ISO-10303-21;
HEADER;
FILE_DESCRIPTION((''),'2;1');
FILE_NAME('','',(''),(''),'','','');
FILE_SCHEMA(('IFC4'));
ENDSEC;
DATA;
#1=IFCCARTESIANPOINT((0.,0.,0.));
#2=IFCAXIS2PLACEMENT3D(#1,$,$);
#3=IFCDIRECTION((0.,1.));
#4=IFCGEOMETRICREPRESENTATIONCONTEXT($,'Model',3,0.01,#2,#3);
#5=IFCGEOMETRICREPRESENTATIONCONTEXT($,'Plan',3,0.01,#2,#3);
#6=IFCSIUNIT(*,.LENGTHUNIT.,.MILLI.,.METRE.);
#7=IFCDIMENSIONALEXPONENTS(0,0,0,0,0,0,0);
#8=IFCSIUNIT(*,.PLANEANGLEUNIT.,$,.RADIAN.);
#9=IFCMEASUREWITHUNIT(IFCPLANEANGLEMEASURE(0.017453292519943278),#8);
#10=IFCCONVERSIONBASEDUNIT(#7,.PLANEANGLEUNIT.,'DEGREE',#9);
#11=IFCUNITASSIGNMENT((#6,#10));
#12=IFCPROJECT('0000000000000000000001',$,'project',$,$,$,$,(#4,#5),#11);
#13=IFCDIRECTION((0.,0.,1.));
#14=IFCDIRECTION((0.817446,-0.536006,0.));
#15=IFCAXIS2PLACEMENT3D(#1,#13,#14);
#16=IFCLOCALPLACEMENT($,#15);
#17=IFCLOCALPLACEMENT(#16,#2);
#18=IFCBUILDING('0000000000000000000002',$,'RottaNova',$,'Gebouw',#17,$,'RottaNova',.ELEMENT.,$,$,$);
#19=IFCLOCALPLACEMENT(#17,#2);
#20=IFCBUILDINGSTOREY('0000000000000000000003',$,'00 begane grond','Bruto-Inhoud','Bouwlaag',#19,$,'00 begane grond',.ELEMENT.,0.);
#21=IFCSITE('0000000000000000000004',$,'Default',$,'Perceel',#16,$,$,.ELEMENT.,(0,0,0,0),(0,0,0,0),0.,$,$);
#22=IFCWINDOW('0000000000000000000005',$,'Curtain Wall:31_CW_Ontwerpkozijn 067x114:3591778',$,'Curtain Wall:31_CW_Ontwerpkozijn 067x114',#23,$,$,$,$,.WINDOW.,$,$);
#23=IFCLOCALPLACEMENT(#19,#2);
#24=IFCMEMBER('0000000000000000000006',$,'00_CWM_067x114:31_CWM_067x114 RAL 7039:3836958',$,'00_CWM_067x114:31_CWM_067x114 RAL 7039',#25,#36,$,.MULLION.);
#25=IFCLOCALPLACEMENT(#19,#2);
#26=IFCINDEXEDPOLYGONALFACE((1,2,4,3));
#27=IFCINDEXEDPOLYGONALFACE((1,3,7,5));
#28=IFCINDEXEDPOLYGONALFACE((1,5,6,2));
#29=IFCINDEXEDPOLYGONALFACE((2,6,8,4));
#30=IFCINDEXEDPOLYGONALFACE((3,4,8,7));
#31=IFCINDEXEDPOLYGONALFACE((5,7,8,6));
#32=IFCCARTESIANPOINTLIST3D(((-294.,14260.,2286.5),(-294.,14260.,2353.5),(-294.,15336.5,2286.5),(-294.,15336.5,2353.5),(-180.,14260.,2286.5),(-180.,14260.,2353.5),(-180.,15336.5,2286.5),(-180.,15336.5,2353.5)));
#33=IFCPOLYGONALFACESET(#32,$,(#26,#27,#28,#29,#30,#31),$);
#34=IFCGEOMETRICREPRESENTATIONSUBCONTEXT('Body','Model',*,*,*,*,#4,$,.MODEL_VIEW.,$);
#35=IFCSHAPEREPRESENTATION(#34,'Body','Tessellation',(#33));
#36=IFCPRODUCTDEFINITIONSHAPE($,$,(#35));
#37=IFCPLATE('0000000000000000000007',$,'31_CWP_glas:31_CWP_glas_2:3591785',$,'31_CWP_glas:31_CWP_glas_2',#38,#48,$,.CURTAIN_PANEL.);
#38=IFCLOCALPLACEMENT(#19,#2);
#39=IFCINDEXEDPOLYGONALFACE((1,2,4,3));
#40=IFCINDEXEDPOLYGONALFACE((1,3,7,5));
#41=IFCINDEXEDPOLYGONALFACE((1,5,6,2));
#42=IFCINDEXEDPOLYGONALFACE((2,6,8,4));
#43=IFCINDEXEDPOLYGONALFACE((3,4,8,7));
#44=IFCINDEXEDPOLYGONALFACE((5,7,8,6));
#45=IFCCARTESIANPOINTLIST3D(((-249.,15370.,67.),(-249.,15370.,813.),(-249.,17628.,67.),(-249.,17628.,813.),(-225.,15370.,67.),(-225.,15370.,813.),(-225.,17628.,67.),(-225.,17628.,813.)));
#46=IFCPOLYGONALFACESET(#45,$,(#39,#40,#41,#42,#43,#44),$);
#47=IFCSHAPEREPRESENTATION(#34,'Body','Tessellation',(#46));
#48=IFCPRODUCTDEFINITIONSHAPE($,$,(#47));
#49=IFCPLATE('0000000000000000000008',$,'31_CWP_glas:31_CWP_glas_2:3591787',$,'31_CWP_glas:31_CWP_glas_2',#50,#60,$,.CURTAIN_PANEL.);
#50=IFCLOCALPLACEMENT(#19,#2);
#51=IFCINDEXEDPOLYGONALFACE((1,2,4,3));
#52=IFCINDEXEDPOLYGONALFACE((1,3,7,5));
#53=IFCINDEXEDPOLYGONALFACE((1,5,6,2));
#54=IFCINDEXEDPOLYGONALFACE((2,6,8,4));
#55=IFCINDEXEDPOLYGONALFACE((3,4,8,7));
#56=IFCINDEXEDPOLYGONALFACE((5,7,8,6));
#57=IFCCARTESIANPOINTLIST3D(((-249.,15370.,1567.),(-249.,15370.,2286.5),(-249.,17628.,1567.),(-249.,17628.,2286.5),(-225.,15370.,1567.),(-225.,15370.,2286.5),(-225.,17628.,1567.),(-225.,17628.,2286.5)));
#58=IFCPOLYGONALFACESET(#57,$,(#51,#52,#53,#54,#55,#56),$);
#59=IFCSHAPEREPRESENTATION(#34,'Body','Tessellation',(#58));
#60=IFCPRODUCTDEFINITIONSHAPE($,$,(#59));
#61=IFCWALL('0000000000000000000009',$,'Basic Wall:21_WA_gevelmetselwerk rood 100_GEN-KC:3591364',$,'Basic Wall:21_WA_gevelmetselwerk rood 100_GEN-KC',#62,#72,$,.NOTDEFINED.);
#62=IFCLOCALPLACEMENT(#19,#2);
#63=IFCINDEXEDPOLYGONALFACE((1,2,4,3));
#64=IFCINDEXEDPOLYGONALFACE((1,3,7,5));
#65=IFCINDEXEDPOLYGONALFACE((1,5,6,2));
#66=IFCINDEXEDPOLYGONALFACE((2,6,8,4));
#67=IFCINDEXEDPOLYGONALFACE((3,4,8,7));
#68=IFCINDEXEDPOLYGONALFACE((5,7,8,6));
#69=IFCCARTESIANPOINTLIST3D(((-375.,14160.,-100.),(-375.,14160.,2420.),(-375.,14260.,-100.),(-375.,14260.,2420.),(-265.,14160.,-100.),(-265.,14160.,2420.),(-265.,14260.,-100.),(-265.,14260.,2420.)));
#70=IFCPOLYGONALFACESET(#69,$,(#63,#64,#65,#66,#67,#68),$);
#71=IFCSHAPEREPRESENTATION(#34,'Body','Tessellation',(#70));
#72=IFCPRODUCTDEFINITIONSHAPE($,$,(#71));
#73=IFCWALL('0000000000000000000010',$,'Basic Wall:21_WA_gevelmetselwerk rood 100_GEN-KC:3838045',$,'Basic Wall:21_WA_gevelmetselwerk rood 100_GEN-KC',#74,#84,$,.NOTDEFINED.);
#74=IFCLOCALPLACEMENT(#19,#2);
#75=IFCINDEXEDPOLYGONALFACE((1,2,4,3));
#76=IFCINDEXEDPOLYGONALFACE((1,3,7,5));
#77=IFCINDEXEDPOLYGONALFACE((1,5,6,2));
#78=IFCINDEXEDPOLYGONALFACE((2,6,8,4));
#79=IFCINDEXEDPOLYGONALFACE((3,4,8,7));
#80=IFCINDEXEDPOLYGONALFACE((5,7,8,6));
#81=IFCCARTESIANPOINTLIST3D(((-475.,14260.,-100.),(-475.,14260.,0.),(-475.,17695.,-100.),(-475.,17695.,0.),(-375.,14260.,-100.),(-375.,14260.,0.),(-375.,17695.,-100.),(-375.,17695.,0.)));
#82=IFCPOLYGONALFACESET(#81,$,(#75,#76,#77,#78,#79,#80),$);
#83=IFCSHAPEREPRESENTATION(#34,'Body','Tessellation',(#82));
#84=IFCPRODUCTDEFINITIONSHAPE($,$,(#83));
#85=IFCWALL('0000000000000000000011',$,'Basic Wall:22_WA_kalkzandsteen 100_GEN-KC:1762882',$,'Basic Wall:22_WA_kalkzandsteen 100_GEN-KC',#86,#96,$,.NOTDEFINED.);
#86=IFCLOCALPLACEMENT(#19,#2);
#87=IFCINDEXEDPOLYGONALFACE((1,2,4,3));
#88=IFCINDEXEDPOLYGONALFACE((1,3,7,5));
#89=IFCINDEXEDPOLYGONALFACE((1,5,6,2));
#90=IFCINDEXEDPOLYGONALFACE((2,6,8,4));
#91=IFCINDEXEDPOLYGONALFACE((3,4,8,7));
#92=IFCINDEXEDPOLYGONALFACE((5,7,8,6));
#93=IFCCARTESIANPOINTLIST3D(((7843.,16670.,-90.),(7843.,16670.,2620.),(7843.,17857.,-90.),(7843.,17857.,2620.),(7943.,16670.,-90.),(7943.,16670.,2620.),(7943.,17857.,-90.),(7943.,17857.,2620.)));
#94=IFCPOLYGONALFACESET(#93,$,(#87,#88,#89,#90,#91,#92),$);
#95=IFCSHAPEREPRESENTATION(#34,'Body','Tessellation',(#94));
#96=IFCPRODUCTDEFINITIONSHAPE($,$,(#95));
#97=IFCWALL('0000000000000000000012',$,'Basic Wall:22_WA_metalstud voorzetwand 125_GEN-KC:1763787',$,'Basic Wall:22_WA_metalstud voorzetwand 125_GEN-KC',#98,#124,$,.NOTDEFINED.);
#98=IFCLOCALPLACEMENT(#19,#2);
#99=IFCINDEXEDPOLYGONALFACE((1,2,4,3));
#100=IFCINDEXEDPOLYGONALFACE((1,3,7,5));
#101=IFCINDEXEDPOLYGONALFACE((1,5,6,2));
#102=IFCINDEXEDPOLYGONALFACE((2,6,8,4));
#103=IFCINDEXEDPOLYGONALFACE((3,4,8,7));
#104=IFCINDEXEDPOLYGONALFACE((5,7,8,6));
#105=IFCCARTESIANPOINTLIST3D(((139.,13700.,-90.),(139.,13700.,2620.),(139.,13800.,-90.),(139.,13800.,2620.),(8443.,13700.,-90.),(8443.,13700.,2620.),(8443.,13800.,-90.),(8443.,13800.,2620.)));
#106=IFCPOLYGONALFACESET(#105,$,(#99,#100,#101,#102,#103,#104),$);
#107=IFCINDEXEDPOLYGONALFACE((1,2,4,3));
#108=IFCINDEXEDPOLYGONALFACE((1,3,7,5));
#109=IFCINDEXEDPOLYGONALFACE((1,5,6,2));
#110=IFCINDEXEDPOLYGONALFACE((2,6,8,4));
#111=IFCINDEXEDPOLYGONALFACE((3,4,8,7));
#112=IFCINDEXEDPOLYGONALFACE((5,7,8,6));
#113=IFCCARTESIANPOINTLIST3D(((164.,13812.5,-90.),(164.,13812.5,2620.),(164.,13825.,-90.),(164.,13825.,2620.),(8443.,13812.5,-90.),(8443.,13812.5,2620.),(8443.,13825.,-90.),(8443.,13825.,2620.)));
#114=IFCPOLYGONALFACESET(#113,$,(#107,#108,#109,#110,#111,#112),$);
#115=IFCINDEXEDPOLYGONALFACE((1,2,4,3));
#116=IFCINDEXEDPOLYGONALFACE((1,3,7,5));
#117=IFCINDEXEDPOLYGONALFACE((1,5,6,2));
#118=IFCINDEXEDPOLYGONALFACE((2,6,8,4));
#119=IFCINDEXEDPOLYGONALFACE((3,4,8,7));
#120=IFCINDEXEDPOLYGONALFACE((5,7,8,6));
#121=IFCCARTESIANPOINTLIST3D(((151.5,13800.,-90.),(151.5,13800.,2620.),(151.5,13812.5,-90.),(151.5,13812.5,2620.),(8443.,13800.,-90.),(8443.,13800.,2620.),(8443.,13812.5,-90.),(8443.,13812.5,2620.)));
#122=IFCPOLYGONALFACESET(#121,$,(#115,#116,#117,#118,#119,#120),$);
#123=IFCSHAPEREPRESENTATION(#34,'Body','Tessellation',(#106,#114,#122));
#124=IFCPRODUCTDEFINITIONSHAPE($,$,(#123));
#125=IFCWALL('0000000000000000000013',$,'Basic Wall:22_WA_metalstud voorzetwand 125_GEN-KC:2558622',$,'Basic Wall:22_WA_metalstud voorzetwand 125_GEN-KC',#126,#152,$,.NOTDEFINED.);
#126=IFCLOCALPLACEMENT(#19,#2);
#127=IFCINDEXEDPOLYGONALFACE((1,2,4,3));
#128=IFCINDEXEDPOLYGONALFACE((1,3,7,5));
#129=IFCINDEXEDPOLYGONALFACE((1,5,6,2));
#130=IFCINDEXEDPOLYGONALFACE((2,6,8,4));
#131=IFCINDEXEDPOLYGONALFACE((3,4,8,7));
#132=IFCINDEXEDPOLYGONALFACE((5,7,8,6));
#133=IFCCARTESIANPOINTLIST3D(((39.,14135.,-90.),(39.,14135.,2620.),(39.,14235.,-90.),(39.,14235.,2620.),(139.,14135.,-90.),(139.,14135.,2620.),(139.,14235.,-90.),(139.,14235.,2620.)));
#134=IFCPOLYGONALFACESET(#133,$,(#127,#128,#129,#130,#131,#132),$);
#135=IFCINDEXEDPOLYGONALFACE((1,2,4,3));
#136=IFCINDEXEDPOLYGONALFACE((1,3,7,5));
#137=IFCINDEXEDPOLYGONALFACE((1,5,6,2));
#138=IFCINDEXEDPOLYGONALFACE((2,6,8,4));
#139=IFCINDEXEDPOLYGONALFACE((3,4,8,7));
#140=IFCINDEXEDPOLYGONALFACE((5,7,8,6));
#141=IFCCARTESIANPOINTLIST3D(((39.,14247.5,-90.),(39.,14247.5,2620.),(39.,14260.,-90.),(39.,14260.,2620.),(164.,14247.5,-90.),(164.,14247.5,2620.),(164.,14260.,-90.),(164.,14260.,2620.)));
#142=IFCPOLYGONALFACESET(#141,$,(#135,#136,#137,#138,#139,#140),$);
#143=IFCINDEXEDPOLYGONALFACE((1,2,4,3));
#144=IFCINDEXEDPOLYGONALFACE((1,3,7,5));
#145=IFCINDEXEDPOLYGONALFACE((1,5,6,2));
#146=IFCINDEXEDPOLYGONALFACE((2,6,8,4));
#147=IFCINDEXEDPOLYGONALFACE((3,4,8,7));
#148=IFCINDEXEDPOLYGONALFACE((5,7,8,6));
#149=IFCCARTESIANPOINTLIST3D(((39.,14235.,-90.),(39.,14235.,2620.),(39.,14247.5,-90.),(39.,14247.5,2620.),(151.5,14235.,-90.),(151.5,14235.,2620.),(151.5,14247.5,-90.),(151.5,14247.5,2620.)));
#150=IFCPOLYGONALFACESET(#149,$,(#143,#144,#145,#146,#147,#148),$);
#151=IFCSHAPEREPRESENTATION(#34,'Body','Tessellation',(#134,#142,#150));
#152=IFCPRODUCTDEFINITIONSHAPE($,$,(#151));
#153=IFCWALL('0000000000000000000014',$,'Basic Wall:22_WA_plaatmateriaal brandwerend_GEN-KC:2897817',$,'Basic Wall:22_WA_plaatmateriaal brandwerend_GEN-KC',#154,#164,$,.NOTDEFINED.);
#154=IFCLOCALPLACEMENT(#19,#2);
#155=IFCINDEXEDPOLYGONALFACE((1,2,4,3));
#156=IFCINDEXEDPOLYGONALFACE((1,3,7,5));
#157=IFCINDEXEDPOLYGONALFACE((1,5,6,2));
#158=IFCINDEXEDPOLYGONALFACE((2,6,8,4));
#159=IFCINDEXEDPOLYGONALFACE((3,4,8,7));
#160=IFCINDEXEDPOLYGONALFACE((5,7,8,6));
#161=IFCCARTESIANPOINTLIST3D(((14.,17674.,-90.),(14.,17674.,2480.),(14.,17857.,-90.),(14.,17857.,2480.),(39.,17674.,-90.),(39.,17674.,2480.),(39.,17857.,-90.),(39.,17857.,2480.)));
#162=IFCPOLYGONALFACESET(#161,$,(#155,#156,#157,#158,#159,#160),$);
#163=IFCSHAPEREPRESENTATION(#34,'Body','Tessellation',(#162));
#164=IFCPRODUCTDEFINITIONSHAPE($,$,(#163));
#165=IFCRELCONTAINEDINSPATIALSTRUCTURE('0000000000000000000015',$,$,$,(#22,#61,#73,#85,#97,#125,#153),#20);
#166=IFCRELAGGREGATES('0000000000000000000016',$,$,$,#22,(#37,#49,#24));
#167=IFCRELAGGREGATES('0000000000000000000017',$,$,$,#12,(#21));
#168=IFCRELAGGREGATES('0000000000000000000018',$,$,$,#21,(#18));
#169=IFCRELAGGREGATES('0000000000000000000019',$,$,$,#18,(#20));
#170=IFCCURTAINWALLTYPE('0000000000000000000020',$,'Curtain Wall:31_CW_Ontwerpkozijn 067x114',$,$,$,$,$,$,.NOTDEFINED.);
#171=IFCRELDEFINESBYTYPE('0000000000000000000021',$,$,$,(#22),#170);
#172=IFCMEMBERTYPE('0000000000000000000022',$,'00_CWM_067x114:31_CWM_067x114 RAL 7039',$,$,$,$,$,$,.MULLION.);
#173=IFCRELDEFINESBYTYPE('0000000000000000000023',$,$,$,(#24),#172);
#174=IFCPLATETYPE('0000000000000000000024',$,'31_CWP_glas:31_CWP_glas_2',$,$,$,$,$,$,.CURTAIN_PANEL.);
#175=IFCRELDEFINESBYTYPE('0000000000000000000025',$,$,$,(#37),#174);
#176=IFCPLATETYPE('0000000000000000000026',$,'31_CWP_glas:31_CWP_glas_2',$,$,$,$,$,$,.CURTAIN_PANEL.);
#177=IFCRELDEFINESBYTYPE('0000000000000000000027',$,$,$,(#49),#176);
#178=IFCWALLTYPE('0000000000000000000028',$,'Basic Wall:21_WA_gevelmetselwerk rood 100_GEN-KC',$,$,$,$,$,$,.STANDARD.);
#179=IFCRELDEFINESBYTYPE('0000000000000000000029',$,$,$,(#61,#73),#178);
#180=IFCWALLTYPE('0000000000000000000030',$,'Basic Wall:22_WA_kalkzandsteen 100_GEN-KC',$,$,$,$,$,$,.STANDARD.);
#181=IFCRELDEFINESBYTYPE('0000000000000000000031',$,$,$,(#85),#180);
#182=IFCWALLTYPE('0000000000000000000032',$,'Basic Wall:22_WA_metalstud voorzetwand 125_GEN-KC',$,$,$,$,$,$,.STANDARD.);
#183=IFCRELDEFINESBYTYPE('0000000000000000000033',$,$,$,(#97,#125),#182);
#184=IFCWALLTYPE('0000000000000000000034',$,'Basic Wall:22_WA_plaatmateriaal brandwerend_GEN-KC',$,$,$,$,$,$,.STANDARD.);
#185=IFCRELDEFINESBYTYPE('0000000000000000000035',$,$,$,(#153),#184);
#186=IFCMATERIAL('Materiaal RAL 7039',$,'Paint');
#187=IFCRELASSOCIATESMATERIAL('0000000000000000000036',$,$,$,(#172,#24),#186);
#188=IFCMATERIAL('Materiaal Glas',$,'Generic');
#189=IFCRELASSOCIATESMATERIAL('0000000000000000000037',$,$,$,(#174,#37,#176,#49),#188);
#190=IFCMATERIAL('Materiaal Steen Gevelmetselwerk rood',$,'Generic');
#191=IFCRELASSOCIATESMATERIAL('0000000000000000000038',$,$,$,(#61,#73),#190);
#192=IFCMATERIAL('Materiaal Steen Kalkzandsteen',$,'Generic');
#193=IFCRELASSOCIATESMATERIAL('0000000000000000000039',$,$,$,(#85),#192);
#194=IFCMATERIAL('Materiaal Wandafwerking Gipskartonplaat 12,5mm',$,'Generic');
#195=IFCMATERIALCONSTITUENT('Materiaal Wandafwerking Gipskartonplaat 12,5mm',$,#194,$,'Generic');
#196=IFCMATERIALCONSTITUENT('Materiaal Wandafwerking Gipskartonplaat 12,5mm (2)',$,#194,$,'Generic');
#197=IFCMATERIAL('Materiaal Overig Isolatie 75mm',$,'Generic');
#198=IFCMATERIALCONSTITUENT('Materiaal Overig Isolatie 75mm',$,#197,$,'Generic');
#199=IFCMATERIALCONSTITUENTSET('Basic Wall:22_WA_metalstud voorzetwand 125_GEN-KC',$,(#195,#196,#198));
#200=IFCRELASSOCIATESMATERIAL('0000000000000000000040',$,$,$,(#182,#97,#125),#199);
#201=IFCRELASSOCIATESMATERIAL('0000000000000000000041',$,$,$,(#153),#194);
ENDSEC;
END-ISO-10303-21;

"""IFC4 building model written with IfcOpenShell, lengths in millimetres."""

from ifc_helpers import new_model, entity, si_unit, converted_unit, direction, frame, origin, place, context, subcontext, project, spatial, indexed_curve, outline, extrude, source, transform, mapped, material, constituent, constituent_set, type_object, type_shapes, element, aggregate, save


model = new_model("IFC4")

# Units and contexts
model_context = context("Model", 3, precision=0.01, world=origin(), true_north=direction((0.0, 1.0)))
plan_context = context("Plan", 3, precision=0.01, world=origin(), true_north=direction((0.0, 1.0)))
body_context = subcontext(model_context, "Body", "Model", "MODEL_VIEW")
ifc_project = project(units=[si_unit("LENGTHUNIT", "METRE", prefix="MILLI"), converted_unit("PLANEANGLEUNIT", "DEGREE", entity("IfcPlaneAngleMeasure", 0.017453292519943278), si_unit("PLANEANGLEUNIT", "RADIAN"), dimensions=[0, 0, 0, 0, 0, 0, 0])], contexts=[model_context, plan_context])

# Site, building, storey
site_placement = place(None, frame((0.0, 0.0, 0.0), z_axis=(0.0, 0.0, 1.0), x_axis=(0.817446, -0.536006, 0.0)))
site = spatial("IfcSite", under=ifc_project, at=site_placement, Name="Default", ObjectType="Perceel", CompositionType="ELEMENT", RefLatitude=(0, 0, 0, 0), RefLongitude=(0, 0, 0, 0), RefElevation=0.0)
building_placement = place(site_placement, origin())
building = spatial("IfcBuilding", under=site, at=building_placement, Name="RottaNova", ObjectType="Gebouw", LongName="RottaNova", CompositionType="ELEMENT")
storey_placement = place(building_placement, origin())
storey = spatial("IfcBuildingStorey", under=building, at=storey_placement, Name="00 begane grond", Description="Bruto-Inhoud", ObjectType="Bouwlaag", LongName="00 begane grond", CompositionType="ELEMENT", Elevation=0.0)

# Window, member, plates
curtain_wall_type = type_object("IfcCurtainWallType", Name="Curtain Wall:31_CW_Ontwerpkozijn 067x114", PredefinedType="NOTDEFINED")
window_1_placement = place(storey_placement, origin())
window_1 = element("IfcWindow", 1, at=window_1_placement, inside=storey, type_object=curtain_wall_type, Name="Curtain Wall:31_CW_Ontwerpkozijn 067x114:3591778", ObjectType="Curtain Wall:31_CW_Ontwerpkozijn 067x114", PredefinedType="WINDOW")
ifc_material_1 = material(Name="Materiaal RAL 7039", Category="Paint")
member_type_1 = type_object("IfcMemberType", Name="00_CWM_067x114:31_CWM_067x114 RAL 7039", PredefinedType="MULLION", material=ifc_material_1)
shared_shape_1 = source(origin(), body_context, "Body", "SweptSolid", [
    extrude(outline(indexed_curve([(-33.5, -57.0), (33.5, -57.0), (33.5, 57.0), (-33.5, 57.0), (-33.5, -57.0)], self_intersect=False)), frame((0.0, -57.0, -1076.5), z_axis=(0.0, 0.0, 1.0), x_axis=(-1.0, 0.0, 0.0)), (0.0, 0.0, 1.0), 1076.5),
])
type_shapes(member_type_1, [shared_shape_1])
member_1_placement = place(window_1_placement, frame((-180.0, 15336.5, 2320.0), z_axis=(0.0, 1.0, 0.0), x_axis=(0.0, 0.0, 1.0)))
member_1 = element("IfcMember", 2, at=member_1_placement, type_object=member_type_1, material=ifc_material_1, Name="00_CWM_067x114:31_CWM_067x114 RAL 7039:3836958", ObjectType="00_CWM_067x114:31_CWM_067x114 RAL 7039", PredefinedType="MULLION", context=body_context, shape_type="MappedRepresentation", body=[
    mapped(shared_shape_1, transform((0.0, 0.0, 0.0), scale=1.0)),
])
ifc_material_2 = material(Name="Materiaal Glas", Category="Generic")
plate_type_1 = type_object("IfcPlateType", Name="31_CWP_glas:31_CWP_glas_2", PredefinedType="CURTAIN_PANEL", material=ifc_material_2)
shared_shape_2 = source(origin(), body_context, "Body", "SweptSolid", [
    extrude(outline(indexed_curve([(-12.0, -1129.0), (12.0, -1129.0), (12.0, 1129.0), (-12.0, 1129.0), (-12.0, -1129.0)], self_intersect=False)), frame((0.0, 57.0, 0.0), z_axis=(0.0, 0.0, 1.0), x_axis=(0.0, 1.0, 0.0)), (0.0, 0.0, 1.0), 746.0),
])
type_shapes(plate_type_1, [shared_shape_2])
plate_1_placement = place(window_1_placement, frame((-180.0, 16499.0, 67.0), z_axis=(0.0, 0.0, 1.0), x_axis=(0.0, 1.0, 0.0)))
plate_1 = element("IfcPlate", 3, at=plate_1_placement, type_object=plate_type_1, material=ifc_material_2, Name="31_CWP_glas:31_CWP_glas_2:3591785", ObjectType="31_CWP_glas:31_CWP_glas_2", PredefinedType="CURTAIN_PANEL", context=body_context, shape_type="MappedRepresentation", body=[
    mapped(shared_shape_2, transform((0.0, 0.0, 0.0), scale=1.0)),
])
plate_type_2 = type_object("IfcPlateType", Name="31_CWP_glas:31_CWP_glas_2", PredefinedType="CURTAIN_PANEL", material=ifc_material_2)
shared_shape_3 = source(origin(), body_context, "Body", "SweptSolid", [
    extrude(outline(indexed_curve([(-12.0, -1129.0), (12.0, -1129.0), (12.0, 1129.0), (-12.0, 1129.0), (-12.0, -1129.0)], self_intersect=False)), frame((0.0, 57.0, 0.0), z_axis=(0.0, 0.0, 1.0), x_axis=(0.0, 1.0, 0.0)), (0.0, 0.0, 1.0), 719.5),
])
type_shapes(plate_type_2, [shared_shape_3])
plate_2_placement = place(window_1_placement, frame((-180.0, 16499.0, 1567.0), z_axis=(0.0, 0.0, 1.0), x_axis=(0.0, 1.0, 0.0)))
plate_2 = element("IfcPlate", 4, at=plate_2_placement, type_object=plate_type_2, material=ifc_material_2, Name="31_CWP_glas:31_CWP_glas_2:3591787", ObjectType="31_CWP_glas:31_CWP_glas_2", PredefinedType="CURTAIN_PANEL", context=body_context, shape_type="MappedRepresentation", body=[
    mapped(shared_shape_3, transform((0.0, 0.0, 0.0), scale=1.0)),
])

# Walls
ifc_material_3 = material(Name="Materiaal Steen Gevelmetselwerk rood", Category="Generic")
wall_type_1 = type_object("IfcWallType", Name="Basic Wall:21_WA_gevelmetselwerk rood 100_GEN-KC", PredefinedType="STANDARD")
wall_1_placement = place(storey_placement, frame((-375.0, 14210.0, -100.0)))
element("IfcWall", 5, at=wall_1_placement, inside=storey, type_object=wall_type_1, material=ifc_material_3, Name="Basic Wall:21_WA_gevelmetselwerk rood 100_GEN-KC:3591364", ObjectType="Basic Wall:21_WA_gevelmetselwerk rood 100_GEN-KC", PredefinedType="NOTDEFINED", context=body_context, shape_type="SweptSolid", body=[
    extrude(outline(indexed_curve([(110.0, 50.0), (0.0, 50.0), (0.0, -50.0), (110.0, -50.0), (110.0, 50.0)], self_intersect=False)), origin(), (0.0, 0.0, 1.0), 2520.0),
])
wall_2_placement = place(storey_placement, frame((-425.0, 14260.0, -100.0), z_axis=(0.0, 0.0, 1.0), x_axis=(0.0, 1.0, 0.0)))
element("IfcWall", 6, at=wall_2_placement, inside=storey, type_object=wall_type_1, material=ifc_material_3, Name="Basic Wall:21_WA_gevelmetselwerk rood 100_GEN-KC:3838045", ObjectType="Basic Wall:21_WA_gevelmetselwerk rood 100_GEN-KC", PredefinedType="NOTDEFINED", context=body_context, shape_type="SweptSolid", body=[
    extrude(outline(indexed_curve([(3435.0, 50.0), (0.0, 50.0), (0.0, -50.0), (3435.0, -50.0), (3435.0, 50.0)], self_intersect=False)), origin(), (0.0, 0.0, 1.0), 100.0),
])
ifc_material_4 = material(Name="Materiaal Steen Kalkzandsteen", Category="Generic")
wall_type_2 = type_object("IfcWallType", Name="Basic Wall:22_WA_kalkzandsteen 100_GEN-KC", PredefinedType="STANDARD")
wall_3_placement = place(storey_placement, frame((7893.0, 17857.0, -90.0), z_axis=(0.0, 0.0, 1.0), x_axis=(0.0, -1.0, 0.0)))
element("IfcWall", 7, at=wall_3_placement, inside=storey, type_object=wall_type_2, material=ifc_material_4, Name="Basic Wall:22_WA_kalkzandsteen 100_GEN-KC:1762882", ObjectType="Basic Wall:22_WA_kalkzandsteen 100_GEN-KC", PredefinedType="NOTDEFINED", context=body_context, shape_type="SweptSolid", body=[
    extrude(outline(indexed_curve([(1187.0, 50.0), (0.0, 50.0), (0.0, -50.0), (1187.0, -50.0), (1187.0, 50.0)], self_intersect=False)), origin(), (0.0, 0.0, 1.0), 2710.0),
])
ifc_material_5 = material(Name="Materiaal Wandafwerking Gipskartonplaat 12,5mm", Category="Generic")
ifc_constituent_1 = constituent(ifc_material_5, Name="Materiaal Wandafwerking Gipskartonplaat 12,5mm", Category="Generic")
ifc_constituent_2 = constituent(ifc_material_5, Name="Materiaal Wandafwerking Gipskartonplaat 12,5mm (2)", Category="Generic")
ifc_material_6 = material(Name="Materiaal Overig Isolatie 75mm", Category="Generic")
ifc_constituent_3 = constituent(ifc_material_6, Name="Materiaal Overig Isolatie 75mm", Category="Generic")
ifc_constituent_set_1 = constituent_set(constituents=[ifc_constituent_1, ifc_constituent_2, ifc_constituent_3], Name="Basic Wall:22_WA_metalstud voorzetwand 125_GEN-KC")
wall_type_3 = type_object("IfcWallType", Name="Basic Wall:22_WA_metalstud voorzetwand 125_GEN-KC", PredefinedType="STANDARD", material=ifc_constituent_set_1)
wall_4_placement = place(storey_placement, frame((164.0, 13762.5, -90.0)))
element("IfcWall", 8, at=wall_4_placement, inside=storey, type_object=wall_type_3, material=ifc_constituent_set_1, Name="Basic Wall:22_WA_metalstud voorzetwand 125_GEN-KC:1763787", ObjectType="Basic Wall:22_WA_metalstud voorzetwand 125_GEN-KC", PredefinedType="NOTDEFINED", context=body_context, shape_type="SweptSolid", body=[
    extrude(outline(indexed_curve([(-50.0, -4152.0), (50.0, -4152.0), (50.0, 4152.0), (-50.0, 4152.0), (-50.0, -4152.0)], self_intersect=False)), frame((4127.0, -12.5, 0.0), z_axis=(0.0, 0.0, 1.0), x_axis=(0.0, 1.0, 0.0)), (0.0, 0.0, 1.0), 2710.0),
    extrude(outline(indexed_curve([(-6.2, -4139.5), (6.3, -4139.5), (6.2, 4139.5), (-6.3, 4139.5), (-6.2, -4139.5)], self_intersect=False)), frame((4139.5, 56.3, 0.0), z_axis=(0.0, 0.0, 1.0), x_axis=(0.0, -1.0, 0.0)), (0.0, 0.0, 1.0), 2710.0),
    extrude(outline(indexed_curve([(-4145.7, -6.2), (4145.7, -6.2), (4145.7, 6.3), (-4145.7, 6.3), (-4145.7, -6.2)], self_intersect=False)), frame((4133.2, 43.7, 0.0)), (0.0, 0.0, 1.0), 2710.0),
])
wall_5_placement = place(storey_placement, frame((164.0, 14197.5, -90.0), z_axis=(0.0, 0.0, 1.0), x_axis=(-1.0, 0.0, 0.0)))
element("IfcWall", 9, at=wall_5_placement, inside=storey, type_object=wall_type_3, material=ifc_constituent_set_1, Name="Basic Wall:22_WA_metalstud voorzetwand 125_GEN-KC:2558622", ObjectType="Basic Wall:22_WA_metalstud voorzetwand 125_GEN-KC", PredefinedType="NOTDEFINED", context=body_context, shape_type="SweptSolid", body=[
    extrude(outline(indexed_curve([(-50.0, -50.0), (50.0, -50.0), (50.0, 50.0), (-50.0, 50.0), (-50.0, -50.0)], self_intersect=False)), frame((75.0, 12.5, 0.0), z_axis=(0.0, 0.0, 1.0), x_axis=(0.0, -1.0, 0.0)), (0.0, 0.0, 1.0), 2710.0),
    extrude(outline(indexed_curve([(-6.2, -62.5), (6.3, -62.5), (6.3, 62.5), (-6.2, 62.5), (-6.2, -62.5)], self_intersect=False)), frame((62.5, -56.3, 0.0), z_axis=(0.0, 0.0, 1.0), x_axis=(0.0, 1.0, 0.0)), (0.0, 0.0, 1.0), 2710.0),
    extrude(outline(indexed_curve([(-56.2, -6.2), (56.2, -6.2), (56.2, 6.3), (-56.2, 6.3), (-56.2, -6.2)], self_intersect=False)), frame((68.7, -43.8, 0.0)), (0.0, 0.0, 1.0), 2710.0),
])
wall_type_4 = type_object("IfcWallType", Name="Basic Wall:22_WA_plaatmateriaal brandwerend_GEN-KC", PredefinedType="STANDARD")
wall_6_placement = place(storey_placement, frame((26.5, 17674.0, -90.0), z_axis=(0.0, 0.0, 1.0), x_axis=(0.0, 1.0, 0.0)))
element("IfcWall", 10, at=wall_6_placement, inside=storey, type_object=wall_type_4, material=ifc_material_5, Name="Basic Wall:22_WA_plaatmateriaal brandwerend_GEN-KC:2897817", ObjectType="Basic Wall:22_WA_plaatmateriaal brandwerend_GEN-KC", PredefinedType="NOTDEFINED", context=body_context, shape_type="SweptSolid", body=[
    extrude(outline(indexed_curve([(183.0, 12.5), (0.0, 12.5), (0.0, -12.5), (183.0, -12.5), (183.0, 12.5)], self_intersect=False)), origin(), (0.0, 0.0, 1.0), 2570.0),
])

aggregate(window_1, [plate_1, plate_2, member_1])

save(model, "model.ifc")
